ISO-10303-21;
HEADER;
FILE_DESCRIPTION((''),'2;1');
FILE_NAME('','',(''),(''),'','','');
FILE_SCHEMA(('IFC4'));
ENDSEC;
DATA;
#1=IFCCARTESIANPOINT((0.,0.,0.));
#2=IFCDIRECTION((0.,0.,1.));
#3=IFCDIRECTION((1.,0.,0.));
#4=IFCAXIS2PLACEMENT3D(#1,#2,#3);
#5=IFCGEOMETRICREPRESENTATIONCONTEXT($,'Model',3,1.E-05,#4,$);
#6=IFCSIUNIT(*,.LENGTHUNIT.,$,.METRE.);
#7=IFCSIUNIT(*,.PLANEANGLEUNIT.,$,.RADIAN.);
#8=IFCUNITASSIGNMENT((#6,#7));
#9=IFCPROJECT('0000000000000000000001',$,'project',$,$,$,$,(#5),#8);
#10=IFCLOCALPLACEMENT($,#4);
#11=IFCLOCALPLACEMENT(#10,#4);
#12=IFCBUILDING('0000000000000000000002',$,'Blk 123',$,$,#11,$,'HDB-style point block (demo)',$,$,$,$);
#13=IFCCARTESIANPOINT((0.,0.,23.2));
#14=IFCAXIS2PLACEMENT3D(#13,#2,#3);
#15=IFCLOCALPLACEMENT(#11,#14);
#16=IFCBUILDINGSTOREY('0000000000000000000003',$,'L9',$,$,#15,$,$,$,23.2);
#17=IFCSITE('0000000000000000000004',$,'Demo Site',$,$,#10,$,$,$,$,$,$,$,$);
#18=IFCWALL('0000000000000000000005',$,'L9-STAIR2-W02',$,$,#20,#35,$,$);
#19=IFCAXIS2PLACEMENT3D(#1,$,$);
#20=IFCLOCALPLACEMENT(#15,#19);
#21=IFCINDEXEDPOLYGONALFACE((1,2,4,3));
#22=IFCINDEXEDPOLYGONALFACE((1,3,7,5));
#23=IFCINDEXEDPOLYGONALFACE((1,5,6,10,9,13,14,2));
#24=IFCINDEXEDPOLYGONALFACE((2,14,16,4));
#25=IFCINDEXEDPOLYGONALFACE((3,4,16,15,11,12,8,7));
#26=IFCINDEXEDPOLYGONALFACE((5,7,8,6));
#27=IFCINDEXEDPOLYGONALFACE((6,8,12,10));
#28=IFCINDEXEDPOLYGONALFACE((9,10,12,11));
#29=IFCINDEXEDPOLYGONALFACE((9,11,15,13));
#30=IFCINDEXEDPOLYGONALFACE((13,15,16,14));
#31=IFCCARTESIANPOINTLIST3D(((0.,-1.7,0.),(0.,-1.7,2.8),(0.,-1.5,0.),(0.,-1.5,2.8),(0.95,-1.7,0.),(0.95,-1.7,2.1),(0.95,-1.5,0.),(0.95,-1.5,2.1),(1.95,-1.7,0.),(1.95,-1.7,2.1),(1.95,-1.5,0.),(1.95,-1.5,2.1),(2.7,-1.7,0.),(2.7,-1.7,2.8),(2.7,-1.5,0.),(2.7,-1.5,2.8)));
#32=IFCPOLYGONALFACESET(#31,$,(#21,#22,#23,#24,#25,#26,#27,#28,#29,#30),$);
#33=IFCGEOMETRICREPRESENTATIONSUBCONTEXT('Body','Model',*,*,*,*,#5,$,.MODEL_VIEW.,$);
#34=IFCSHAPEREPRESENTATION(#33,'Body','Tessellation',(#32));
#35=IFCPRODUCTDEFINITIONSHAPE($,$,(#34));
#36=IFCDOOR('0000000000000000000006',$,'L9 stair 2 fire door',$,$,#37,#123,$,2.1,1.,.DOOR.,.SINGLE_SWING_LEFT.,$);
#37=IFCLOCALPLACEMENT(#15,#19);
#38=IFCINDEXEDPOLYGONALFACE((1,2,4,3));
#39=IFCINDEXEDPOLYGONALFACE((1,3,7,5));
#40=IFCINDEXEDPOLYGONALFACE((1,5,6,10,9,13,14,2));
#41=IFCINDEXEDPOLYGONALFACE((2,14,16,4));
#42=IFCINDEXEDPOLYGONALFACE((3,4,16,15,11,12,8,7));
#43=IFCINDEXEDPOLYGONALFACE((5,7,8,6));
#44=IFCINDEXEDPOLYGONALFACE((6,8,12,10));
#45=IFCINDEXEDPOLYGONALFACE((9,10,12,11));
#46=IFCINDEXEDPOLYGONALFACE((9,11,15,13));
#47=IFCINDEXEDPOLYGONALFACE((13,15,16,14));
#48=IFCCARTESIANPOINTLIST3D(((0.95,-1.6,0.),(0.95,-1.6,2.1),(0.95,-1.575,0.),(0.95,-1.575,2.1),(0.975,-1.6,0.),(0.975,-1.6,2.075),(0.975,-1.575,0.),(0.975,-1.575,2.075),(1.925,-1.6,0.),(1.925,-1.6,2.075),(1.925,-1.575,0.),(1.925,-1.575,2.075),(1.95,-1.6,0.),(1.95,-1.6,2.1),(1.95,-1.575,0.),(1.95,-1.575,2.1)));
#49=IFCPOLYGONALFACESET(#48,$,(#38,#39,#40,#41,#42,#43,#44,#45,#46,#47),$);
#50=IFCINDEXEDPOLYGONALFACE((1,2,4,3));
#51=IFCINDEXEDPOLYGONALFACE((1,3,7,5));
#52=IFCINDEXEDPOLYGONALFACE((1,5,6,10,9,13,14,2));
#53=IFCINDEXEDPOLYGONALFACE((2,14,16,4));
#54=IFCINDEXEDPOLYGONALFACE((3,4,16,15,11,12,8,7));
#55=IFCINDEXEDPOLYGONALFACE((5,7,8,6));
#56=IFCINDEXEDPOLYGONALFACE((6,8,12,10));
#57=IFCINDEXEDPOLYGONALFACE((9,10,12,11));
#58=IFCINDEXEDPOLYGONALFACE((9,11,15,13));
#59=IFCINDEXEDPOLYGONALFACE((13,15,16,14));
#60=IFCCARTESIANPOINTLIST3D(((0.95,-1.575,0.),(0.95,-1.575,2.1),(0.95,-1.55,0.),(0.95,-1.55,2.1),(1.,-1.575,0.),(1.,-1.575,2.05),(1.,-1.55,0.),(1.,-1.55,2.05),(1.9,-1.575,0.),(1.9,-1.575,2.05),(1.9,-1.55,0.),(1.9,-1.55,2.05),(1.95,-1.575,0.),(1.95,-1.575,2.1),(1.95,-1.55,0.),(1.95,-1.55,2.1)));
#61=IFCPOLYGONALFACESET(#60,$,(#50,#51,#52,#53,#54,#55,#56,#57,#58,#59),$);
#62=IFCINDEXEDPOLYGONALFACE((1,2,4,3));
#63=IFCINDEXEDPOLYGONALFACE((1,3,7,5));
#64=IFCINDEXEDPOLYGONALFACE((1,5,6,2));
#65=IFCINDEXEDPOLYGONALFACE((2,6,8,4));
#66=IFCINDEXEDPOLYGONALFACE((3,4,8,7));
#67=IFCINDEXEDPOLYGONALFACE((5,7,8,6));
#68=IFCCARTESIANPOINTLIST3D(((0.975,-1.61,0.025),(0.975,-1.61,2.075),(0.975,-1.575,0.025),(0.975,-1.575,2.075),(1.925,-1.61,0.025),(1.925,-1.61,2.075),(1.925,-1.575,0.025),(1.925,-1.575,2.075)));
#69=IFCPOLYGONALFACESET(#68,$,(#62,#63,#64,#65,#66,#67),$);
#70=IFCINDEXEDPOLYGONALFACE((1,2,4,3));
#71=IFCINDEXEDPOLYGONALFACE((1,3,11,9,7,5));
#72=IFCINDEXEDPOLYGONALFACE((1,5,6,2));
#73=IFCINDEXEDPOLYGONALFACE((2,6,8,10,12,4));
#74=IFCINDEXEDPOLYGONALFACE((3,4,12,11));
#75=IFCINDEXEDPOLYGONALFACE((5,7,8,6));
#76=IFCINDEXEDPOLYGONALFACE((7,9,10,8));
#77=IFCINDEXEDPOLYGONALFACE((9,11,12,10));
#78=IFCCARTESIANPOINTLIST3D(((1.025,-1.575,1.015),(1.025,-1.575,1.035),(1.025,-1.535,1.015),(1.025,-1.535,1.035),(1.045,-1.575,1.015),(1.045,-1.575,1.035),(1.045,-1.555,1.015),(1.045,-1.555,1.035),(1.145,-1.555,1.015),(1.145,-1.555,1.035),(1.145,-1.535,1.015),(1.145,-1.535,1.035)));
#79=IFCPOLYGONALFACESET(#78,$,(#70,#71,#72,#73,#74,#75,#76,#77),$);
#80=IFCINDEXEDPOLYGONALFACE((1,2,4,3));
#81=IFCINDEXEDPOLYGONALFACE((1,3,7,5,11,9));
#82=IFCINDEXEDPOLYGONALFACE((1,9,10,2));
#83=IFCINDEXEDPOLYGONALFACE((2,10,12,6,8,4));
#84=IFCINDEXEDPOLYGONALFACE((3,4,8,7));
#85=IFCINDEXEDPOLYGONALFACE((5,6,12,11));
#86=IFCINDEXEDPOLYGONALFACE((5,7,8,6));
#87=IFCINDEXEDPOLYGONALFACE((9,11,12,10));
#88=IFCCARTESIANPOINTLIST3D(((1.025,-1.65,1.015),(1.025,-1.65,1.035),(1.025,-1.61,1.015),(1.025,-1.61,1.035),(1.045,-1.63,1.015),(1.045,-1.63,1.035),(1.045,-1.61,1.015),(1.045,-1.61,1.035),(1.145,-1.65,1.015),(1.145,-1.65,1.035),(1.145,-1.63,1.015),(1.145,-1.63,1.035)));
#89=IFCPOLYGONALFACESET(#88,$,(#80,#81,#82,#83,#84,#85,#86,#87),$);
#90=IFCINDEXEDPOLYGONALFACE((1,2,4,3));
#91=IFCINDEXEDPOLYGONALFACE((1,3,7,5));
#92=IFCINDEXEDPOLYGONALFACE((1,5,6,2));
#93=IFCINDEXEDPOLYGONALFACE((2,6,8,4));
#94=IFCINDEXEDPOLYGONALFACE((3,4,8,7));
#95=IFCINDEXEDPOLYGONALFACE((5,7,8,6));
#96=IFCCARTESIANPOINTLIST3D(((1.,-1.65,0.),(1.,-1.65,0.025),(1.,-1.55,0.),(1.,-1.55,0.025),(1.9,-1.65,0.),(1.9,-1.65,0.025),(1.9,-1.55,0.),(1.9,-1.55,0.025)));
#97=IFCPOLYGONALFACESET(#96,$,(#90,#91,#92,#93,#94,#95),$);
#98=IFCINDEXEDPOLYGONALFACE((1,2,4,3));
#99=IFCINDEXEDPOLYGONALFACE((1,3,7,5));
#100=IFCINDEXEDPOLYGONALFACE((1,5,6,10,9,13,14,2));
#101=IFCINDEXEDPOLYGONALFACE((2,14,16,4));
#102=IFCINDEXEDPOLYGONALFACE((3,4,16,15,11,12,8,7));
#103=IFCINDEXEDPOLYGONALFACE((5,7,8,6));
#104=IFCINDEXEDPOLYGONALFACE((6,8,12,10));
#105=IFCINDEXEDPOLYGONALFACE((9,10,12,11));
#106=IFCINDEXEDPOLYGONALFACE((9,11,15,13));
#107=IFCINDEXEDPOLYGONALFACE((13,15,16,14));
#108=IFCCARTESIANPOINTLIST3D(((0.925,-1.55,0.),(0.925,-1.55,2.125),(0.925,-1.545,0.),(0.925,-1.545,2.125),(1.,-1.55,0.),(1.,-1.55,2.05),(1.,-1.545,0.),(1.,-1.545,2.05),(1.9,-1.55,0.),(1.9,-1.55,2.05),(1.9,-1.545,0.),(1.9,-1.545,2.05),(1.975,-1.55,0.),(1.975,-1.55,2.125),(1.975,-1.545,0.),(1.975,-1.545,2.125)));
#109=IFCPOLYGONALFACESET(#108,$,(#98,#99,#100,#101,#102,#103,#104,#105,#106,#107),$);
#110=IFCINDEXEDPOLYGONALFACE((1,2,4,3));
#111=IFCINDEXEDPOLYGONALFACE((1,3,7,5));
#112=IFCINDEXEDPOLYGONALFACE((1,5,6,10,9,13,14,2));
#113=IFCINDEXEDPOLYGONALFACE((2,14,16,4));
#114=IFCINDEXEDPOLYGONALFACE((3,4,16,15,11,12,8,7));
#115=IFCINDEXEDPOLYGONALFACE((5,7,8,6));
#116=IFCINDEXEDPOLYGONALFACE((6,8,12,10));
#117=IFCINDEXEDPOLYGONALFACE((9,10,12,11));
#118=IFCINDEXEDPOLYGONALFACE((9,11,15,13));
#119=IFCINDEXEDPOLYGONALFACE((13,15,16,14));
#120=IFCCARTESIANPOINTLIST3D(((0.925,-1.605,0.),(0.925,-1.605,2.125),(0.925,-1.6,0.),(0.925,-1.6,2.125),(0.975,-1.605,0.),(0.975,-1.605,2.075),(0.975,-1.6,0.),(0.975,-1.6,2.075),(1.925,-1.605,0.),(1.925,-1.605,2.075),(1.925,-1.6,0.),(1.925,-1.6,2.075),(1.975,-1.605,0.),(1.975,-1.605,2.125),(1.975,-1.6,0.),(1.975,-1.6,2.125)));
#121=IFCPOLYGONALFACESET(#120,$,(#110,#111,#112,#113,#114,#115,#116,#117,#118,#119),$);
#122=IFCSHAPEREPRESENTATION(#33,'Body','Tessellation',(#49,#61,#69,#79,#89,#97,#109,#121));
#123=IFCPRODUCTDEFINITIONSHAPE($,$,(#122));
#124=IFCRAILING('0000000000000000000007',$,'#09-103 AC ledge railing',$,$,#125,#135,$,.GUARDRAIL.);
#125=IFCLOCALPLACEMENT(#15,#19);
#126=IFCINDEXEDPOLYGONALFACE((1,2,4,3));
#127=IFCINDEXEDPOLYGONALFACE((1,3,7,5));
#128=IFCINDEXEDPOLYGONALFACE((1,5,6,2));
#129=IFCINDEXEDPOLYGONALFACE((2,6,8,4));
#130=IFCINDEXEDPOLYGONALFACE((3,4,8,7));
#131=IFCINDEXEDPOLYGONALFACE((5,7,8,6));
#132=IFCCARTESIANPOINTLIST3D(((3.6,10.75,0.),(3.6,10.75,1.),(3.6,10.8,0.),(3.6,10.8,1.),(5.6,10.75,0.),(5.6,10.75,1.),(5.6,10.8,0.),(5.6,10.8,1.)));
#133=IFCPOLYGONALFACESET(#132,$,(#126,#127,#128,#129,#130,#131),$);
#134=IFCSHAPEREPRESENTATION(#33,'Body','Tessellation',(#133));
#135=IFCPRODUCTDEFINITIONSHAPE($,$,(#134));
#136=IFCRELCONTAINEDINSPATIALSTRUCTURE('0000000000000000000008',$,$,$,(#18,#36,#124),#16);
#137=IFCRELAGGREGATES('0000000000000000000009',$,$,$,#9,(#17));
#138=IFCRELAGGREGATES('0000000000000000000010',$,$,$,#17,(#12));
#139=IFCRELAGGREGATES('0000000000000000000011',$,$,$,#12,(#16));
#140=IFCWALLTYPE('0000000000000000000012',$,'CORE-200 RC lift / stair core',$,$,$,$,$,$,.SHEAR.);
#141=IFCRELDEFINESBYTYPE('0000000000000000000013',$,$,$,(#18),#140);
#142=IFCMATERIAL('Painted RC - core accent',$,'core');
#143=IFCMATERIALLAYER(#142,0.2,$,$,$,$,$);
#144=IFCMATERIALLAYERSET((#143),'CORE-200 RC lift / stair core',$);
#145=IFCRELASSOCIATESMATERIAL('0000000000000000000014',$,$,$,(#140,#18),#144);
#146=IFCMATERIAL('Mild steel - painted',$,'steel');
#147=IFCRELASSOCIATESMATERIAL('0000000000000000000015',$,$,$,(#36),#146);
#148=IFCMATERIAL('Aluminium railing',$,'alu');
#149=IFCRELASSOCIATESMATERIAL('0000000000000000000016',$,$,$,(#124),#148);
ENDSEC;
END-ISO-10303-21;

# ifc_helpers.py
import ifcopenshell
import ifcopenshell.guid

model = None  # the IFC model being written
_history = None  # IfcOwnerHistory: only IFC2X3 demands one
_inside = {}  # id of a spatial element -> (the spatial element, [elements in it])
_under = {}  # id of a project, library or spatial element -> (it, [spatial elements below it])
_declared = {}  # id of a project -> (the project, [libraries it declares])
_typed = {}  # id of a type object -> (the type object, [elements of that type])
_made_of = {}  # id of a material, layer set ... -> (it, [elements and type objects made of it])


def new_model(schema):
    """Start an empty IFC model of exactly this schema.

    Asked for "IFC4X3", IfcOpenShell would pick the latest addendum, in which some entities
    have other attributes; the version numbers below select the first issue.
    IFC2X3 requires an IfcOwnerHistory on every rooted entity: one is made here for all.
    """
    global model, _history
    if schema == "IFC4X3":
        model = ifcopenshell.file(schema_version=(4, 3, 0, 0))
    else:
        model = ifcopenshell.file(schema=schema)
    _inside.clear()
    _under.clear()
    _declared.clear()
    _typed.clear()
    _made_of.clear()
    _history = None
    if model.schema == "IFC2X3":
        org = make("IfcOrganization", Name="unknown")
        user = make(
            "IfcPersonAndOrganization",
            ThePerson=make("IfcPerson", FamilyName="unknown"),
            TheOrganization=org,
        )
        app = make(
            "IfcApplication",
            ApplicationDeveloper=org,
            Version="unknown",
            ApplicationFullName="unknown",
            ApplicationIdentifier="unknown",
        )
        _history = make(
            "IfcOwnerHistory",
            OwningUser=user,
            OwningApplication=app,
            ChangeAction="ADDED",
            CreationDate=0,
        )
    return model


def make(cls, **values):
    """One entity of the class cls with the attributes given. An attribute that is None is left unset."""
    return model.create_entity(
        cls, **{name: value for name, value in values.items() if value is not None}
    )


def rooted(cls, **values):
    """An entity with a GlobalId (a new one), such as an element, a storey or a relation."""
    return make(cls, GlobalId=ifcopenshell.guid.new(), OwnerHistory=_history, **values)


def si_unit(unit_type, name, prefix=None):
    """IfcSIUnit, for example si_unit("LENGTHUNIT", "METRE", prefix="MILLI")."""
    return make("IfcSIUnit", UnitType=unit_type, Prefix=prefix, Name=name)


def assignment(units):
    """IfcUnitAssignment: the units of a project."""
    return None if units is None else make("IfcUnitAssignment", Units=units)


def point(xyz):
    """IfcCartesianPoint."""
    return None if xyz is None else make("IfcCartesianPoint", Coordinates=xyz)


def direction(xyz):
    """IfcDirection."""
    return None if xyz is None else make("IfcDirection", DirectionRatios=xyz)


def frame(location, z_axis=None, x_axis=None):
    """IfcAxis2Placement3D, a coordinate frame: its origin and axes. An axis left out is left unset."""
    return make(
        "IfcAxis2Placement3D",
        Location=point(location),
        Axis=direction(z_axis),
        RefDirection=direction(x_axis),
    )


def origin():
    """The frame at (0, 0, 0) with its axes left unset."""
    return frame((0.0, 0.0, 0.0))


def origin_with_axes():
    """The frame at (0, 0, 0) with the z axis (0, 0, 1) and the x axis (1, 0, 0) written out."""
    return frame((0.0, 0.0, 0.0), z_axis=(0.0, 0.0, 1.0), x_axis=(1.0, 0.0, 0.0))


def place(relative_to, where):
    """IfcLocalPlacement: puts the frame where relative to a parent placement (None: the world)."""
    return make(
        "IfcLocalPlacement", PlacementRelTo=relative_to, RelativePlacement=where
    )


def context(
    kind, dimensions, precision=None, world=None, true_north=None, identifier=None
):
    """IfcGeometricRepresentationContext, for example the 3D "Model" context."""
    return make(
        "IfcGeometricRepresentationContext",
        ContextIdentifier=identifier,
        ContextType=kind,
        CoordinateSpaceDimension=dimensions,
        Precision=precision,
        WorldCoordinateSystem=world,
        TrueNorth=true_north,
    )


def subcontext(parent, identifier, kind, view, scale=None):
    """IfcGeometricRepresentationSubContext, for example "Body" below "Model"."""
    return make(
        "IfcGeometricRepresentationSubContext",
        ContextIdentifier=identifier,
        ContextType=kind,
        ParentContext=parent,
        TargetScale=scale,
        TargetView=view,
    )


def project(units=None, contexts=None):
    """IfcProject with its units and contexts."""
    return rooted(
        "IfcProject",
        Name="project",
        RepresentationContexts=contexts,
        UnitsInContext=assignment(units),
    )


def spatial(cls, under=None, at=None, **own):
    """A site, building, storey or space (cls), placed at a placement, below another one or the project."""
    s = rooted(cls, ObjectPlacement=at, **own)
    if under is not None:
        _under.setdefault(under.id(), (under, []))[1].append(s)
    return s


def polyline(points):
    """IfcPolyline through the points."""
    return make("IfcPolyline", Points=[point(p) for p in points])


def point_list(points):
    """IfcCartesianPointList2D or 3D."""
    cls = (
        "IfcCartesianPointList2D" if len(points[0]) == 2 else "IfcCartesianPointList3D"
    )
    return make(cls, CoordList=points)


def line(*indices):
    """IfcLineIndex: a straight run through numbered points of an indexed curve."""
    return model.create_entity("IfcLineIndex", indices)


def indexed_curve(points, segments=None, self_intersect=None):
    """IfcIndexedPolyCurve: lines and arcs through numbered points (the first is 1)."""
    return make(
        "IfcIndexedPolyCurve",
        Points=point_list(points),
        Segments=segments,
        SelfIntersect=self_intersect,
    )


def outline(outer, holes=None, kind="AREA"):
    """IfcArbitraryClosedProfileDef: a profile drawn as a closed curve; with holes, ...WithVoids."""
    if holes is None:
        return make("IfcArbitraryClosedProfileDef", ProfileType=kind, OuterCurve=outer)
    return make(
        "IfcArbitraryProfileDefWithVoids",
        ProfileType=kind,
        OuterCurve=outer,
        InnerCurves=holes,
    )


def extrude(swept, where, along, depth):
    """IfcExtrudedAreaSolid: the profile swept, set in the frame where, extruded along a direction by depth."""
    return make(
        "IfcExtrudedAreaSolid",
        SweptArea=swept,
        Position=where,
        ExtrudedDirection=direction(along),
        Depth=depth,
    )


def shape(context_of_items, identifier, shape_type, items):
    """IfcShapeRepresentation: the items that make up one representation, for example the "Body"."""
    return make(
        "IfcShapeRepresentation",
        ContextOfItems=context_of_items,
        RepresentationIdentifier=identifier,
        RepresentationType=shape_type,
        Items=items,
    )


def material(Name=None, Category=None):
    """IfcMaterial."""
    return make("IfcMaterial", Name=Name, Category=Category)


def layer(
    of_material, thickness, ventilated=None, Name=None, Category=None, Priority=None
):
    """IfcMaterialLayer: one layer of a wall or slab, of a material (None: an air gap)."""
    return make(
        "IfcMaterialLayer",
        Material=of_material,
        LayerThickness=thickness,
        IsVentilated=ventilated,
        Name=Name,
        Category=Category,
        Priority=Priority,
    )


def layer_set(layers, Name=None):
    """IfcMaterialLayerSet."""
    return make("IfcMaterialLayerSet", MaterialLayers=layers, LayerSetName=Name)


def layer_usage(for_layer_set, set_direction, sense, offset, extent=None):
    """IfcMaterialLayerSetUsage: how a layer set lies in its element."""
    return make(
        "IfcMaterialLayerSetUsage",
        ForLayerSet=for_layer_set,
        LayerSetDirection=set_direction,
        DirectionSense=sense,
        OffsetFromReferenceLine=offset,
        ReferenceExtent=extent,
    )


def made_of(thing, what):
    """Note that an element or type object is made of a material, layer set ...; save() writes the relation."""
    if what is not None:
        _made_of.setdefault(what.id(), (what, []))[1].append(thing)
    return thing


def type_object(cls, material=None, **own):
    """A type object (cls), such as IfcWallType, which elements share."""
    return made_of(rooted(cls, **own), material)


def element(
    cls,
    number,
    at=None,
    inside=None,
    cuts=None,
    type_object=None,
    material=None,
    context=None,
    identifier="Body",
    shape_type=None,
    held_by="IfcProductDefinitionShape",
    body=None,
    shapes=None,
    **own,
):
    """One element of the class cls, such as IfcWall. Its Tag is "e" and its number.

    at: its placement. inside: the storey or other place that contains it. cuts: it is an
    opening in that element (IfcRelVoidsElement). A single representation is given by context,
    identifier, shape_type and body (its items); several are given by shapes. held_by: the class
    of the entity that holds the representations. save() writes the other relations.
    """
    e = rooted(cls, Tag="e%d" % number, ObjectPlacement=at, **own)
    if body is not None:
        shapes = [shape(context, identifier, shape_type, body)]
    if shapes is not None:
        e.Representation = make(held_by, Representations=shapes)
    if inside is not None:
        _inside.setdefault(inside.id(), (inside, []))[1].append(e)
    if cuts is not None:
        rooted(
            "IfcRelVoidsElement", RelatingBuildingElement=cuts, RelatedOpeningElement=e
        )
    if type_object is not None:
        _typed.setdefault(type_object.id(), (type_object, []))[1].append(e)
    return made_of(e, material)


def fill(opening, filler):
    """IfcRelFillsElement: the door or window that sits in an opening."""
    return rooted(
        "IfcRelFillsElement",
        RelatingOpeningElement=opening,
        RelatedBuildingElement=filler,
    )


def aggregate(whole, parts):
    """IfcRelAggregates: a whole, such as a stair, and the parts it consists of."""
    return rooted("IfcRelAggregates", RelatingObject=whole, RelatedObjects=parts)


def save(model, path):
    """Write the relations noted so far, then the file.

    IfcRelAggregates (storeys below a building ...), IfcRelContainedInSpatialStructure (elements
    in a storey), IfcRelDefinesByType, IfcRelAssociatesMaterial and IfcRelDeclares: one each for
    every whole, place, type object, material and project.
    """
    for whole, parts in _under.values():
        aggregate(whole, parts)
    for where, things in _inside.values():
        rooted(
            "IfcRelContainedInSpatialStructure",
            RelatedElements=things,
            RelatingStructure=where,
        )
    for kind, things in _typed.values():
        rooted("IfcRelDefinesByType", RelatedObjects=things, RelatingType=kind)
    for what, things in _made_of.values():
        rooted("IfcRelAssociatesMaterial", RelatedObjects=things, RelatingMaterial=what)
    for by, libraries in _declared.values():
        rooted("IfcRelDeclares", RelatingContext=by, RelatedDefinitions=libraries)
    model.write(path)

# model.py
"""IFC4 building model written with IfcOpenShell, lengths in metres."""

from ifc_helpers import new_model, si_unit, frame, origin, origin_with_axes, place, context, subcontext, project, spatial, polyline, line, indexed_curve, outline, extrude, material, layer, layer_set, layer_usage, type_object, element, fill, save


model = new_model("IFC4")

# Units and contexts
model_context = context("Model", 3, precision=1e-05, world=origin_with_axes())
body_context = subcontext(model_context, "Body", "Model", "MODEL_VIEW")
ifc_project = project(units=[si_unit("LENGTHUNIT", "METRE"), si_unit("PLANEANGLEUNIT", "RADIAN")], contexts=[model_context])

# Site, building, storey
site_placement = place(None, origin_with_axes())
site = spatial("IfcSite", under=ifc_project, at=site_placement, Name="Demo Site")
building_placement = place(site_placement, origin_with_axes())
building = spatial("IfcBuilding", under=site, at=building_placement, Name="Blk 123", LongName="HDB-style point block (demo)")
storey_placement = place(building_placement, frame((0.0, 0.0, 23.2), z_axis=(0.0, 0.0, 1.0), x_axis=(1.0, 0.0, 0.0)))
storey = spatial("IfcBuildingStorey", under=building, at=storey_placement, Name="L9", Elevation=23.2)

# Shared definitions
ifc_material_1 = material(Name="Painted RC - core accent", Category="core")
ifc_layer_1 = layer(ifc_material_1, 0.2)
ifc_layer_set_1 = layer_set([ifc_layer_1], Name="CORE-200 RC lift / stair core")
ifc_layer_usage_1 = layer_usage(ifc_layer_set_1, "AXIS2", "POSITIVE", 0.0)
wall_type_1 = type_object("IfcWallType", Name="CORE-200 RC lift / stair core", PredefinedType="SHEAR", material=ifc_layer_set_1)

# Wall, opening, door
wall_1_placement = place(storey_placement, frame((2.7, -1.5, 0.0), z_axis=(0.0, 0.0, 1.0), x_axis=(-1.0, 0.0, 0.0)))
wall_1 = element("IfcWall", 1, at=wall_1_placement, inside=storey, type_object=wall_type_1, material=ifc_layer_usage_1, Name="L9-STAIR2-W02", context=body_context, shape_type="SweptSolid", body=[
    extrude(outline(indexed_curve([(0.0, 0.0), (0.0, 0.2), (2.7, 0.2), (2.7, 0.0), (0.0, 0.0)], self_intersect=False)), origin_with_axes(), (0.0, 0.0, 1.0), 2.8),
])
opening_1_placement = place(wall_1_placement, frame((0.75, -0.1, 0.0), z_axis=(0.0, 0.0, 1.0), x_axis=(1.0, 0.0, 0.0)))
opening_1 = element("IfcOpeningElement", 2, at=opening_1_placement, cuts=wall_1, context=body_context, shape_type="SweptSolid", body=[
    extrude(outline(indexed_curve([(0.0, 0.0), (0.0, 0.4), (1.0, 0.4), (1.0, 0.0), (0.0, 0.0)], self_intersect=False)), origin_with_axes(), (0.0, 0.0, 1.0), 2.1),
])
ifc_material_2 = material(Name="Mild steel - painted", Category="steel")
door_1_placement = place(opening_1_placement, frame((0.0, 0.15, 0.0), z_axis=(0.0, 0.0, 1.0), x_axis=(1.0, 0.0, 0.0)))
door_1 = element("IfcDoor", 3, at=door_1_placement, inside=storey, material=ifc_material_2, Name="L9 stair 2 fire door", OperationType="SINGLE_SWING_LEFT", OverallHeight=2.1, OverallWidth=1.0, PredefinedType="DOOR", context=body_context, shape_type="SweptSolid", body=[
    extrude(outline(indexed_curve([(0.0, 0.0), (0.0, 2.1), (1.0, 2.1), (1.0, 0.0), (0.975, 0.0), (0.975, 2.075), (0.025, 2.075), (0.025, 0.0)], segments=[line(1, 2, 3, 4, 5, 6, 7, 8, 1)])), frame((0.0, 0.025, 0.0), z_axis=(0.0, -1.0, 0.0), x_axis=(1.0, 0.0, 0.0)), (0.0, 0.0, -1.0), 0.025),
    extrude(outline(indexed_curve([(0.0, 0.0), (0.0, 2.1), (1.0, 2.1), (1.0, 0.0), (0.95, 0.0), (0.95, 2.05), (0.05, 2.05), (0.05, 0.0)], segments=[line(1, 2, 3, 4, 5, 6, 7, 8, 1)])), frame((0.0, 0.0, 0.0), z_axis=(0.0, -1.0, 0.0), x_axis=(1.0, 0.0, 0.0)), (0.0, 0.0, -1.0), 0.025),
    extrude(outline(indexed_curve([(0.0, 0.0), (0.95, 0.0), (0.95, 0.035), (0.0, 0.035)], segments=[line(1, 2, 3, 4, 1)])), frame((0.025, 0.025, 0.025), z_axis=(0.0, 0.0, 1.0), x_axis=(1.0, 0.0, 0.0)), (0.0, 0.0, 1.0), 2.05),
    extrude(outline(indexed_curve([(0.0, 0.0), (0.0, -0.04), (-0.12, -0.04), (-0.12, -0.02), (-0.02, -0.02), (-0.02, 0.0)], segments=[line(1, 2, 3, 4, 5, 6, 1)])), frame((0.925, 0.025, 1.015), z_axis=(0.0, 0.0, 1.0), x_axis=(1.0, 0.0, 0.0)), (0.0, 0.0, 1.0), 0.02),
    extrude(outline(indexed_curve([(0.0, 0.0), (0.0, 0.04), (-0.12, 0.04), (-0.12, 0.02), (-0.02, 0.02), (-0.02, 0.0)], segments=[line(1, 2, 3, 4, 5, 6, 1)])), frame((0.925, 0.06, 1.015), z_axis=(0.0, 0.0, 1.0), x_axis=(1.0, 0.0, 0.0)), (0.0, 0.0, 1.0), 0.02),
    extrude(outline(indexed_curve([(0.0, 0.0), (0.9, 0.0), (0.9, 0.1), (0.0, 0.1)], segments=[line(1, 2, 3, 4, 1)])), frame((0.05, 0.0, 0.0), z_axis=(0.0, 0.0, 1.0), x_axis=(1.0, 0.0, 0.0)), (0.0, 0.0, 1.0), 0.025),
    extrude(outline(indexed_curve([(0.0, 0.0), (0.0, 2.125), (1.05, 2.125), (1.05, 0.0), (0.975, 0.0), (0.975, 2.05), (0.075, 2.05), (0.075, 0.0)], segments=[line(1, 2, 3, 4, 5, 6, 7, 8, 1)])), frame((-0.025, -0.005, 0.0), z_axis=(0.0, -1.0, 0.0), x_axis=(1.0, 0.0, 0.0)), (0.0, 0.0, -1.0), 0.005),
    extrude(outline(indexed_curve([(0.0, 0.0), (0.0, 2.125), (1.05, 2.125), (1.05, 0.0), (1.0, 0.0), (1.0, 2.075), (0.05, 2.075), (0.05, 0.0)], segments=[line(1, 2, 3, 4, 5, 6, 7, 8, 1)])), frame((-0.025, 0.05, 0.0), z_axis=(0.0, -1.0, 0.0), x_axis=(1.0, 0.0, 0.0)), (0.0, 0.0, -1.0), 0.005),
])
fill(opening_1, door_1)

# Railing
ifc_material_3 = material(Name="Aluminium railing", Category="alu")
railing_placement = place(storey_placement, frame((4.6, 10.775, 0.0), z_axis=(0.0, 0.0, 1.0), x_axis=(1.0, 0.0, 0.0)))
element("IfcRailing", 4, at=railing_placement, inside=storey, material=ifc_material_3, Name="#09-103 AC ledge railing", PredefinedType="GUARDRAIL", context=body_context, shape_type="SweptSolid", body=[
    extrude(outline(polyline([(1.0, -0.025), (1.0, 0.025), (-1.0, 0.025), (-1.0, -0.025), (1.0, -0.025)])), origin(), (0.0, 0.0, 1.0), 1.0),
])

save(model, "model.ifc")
